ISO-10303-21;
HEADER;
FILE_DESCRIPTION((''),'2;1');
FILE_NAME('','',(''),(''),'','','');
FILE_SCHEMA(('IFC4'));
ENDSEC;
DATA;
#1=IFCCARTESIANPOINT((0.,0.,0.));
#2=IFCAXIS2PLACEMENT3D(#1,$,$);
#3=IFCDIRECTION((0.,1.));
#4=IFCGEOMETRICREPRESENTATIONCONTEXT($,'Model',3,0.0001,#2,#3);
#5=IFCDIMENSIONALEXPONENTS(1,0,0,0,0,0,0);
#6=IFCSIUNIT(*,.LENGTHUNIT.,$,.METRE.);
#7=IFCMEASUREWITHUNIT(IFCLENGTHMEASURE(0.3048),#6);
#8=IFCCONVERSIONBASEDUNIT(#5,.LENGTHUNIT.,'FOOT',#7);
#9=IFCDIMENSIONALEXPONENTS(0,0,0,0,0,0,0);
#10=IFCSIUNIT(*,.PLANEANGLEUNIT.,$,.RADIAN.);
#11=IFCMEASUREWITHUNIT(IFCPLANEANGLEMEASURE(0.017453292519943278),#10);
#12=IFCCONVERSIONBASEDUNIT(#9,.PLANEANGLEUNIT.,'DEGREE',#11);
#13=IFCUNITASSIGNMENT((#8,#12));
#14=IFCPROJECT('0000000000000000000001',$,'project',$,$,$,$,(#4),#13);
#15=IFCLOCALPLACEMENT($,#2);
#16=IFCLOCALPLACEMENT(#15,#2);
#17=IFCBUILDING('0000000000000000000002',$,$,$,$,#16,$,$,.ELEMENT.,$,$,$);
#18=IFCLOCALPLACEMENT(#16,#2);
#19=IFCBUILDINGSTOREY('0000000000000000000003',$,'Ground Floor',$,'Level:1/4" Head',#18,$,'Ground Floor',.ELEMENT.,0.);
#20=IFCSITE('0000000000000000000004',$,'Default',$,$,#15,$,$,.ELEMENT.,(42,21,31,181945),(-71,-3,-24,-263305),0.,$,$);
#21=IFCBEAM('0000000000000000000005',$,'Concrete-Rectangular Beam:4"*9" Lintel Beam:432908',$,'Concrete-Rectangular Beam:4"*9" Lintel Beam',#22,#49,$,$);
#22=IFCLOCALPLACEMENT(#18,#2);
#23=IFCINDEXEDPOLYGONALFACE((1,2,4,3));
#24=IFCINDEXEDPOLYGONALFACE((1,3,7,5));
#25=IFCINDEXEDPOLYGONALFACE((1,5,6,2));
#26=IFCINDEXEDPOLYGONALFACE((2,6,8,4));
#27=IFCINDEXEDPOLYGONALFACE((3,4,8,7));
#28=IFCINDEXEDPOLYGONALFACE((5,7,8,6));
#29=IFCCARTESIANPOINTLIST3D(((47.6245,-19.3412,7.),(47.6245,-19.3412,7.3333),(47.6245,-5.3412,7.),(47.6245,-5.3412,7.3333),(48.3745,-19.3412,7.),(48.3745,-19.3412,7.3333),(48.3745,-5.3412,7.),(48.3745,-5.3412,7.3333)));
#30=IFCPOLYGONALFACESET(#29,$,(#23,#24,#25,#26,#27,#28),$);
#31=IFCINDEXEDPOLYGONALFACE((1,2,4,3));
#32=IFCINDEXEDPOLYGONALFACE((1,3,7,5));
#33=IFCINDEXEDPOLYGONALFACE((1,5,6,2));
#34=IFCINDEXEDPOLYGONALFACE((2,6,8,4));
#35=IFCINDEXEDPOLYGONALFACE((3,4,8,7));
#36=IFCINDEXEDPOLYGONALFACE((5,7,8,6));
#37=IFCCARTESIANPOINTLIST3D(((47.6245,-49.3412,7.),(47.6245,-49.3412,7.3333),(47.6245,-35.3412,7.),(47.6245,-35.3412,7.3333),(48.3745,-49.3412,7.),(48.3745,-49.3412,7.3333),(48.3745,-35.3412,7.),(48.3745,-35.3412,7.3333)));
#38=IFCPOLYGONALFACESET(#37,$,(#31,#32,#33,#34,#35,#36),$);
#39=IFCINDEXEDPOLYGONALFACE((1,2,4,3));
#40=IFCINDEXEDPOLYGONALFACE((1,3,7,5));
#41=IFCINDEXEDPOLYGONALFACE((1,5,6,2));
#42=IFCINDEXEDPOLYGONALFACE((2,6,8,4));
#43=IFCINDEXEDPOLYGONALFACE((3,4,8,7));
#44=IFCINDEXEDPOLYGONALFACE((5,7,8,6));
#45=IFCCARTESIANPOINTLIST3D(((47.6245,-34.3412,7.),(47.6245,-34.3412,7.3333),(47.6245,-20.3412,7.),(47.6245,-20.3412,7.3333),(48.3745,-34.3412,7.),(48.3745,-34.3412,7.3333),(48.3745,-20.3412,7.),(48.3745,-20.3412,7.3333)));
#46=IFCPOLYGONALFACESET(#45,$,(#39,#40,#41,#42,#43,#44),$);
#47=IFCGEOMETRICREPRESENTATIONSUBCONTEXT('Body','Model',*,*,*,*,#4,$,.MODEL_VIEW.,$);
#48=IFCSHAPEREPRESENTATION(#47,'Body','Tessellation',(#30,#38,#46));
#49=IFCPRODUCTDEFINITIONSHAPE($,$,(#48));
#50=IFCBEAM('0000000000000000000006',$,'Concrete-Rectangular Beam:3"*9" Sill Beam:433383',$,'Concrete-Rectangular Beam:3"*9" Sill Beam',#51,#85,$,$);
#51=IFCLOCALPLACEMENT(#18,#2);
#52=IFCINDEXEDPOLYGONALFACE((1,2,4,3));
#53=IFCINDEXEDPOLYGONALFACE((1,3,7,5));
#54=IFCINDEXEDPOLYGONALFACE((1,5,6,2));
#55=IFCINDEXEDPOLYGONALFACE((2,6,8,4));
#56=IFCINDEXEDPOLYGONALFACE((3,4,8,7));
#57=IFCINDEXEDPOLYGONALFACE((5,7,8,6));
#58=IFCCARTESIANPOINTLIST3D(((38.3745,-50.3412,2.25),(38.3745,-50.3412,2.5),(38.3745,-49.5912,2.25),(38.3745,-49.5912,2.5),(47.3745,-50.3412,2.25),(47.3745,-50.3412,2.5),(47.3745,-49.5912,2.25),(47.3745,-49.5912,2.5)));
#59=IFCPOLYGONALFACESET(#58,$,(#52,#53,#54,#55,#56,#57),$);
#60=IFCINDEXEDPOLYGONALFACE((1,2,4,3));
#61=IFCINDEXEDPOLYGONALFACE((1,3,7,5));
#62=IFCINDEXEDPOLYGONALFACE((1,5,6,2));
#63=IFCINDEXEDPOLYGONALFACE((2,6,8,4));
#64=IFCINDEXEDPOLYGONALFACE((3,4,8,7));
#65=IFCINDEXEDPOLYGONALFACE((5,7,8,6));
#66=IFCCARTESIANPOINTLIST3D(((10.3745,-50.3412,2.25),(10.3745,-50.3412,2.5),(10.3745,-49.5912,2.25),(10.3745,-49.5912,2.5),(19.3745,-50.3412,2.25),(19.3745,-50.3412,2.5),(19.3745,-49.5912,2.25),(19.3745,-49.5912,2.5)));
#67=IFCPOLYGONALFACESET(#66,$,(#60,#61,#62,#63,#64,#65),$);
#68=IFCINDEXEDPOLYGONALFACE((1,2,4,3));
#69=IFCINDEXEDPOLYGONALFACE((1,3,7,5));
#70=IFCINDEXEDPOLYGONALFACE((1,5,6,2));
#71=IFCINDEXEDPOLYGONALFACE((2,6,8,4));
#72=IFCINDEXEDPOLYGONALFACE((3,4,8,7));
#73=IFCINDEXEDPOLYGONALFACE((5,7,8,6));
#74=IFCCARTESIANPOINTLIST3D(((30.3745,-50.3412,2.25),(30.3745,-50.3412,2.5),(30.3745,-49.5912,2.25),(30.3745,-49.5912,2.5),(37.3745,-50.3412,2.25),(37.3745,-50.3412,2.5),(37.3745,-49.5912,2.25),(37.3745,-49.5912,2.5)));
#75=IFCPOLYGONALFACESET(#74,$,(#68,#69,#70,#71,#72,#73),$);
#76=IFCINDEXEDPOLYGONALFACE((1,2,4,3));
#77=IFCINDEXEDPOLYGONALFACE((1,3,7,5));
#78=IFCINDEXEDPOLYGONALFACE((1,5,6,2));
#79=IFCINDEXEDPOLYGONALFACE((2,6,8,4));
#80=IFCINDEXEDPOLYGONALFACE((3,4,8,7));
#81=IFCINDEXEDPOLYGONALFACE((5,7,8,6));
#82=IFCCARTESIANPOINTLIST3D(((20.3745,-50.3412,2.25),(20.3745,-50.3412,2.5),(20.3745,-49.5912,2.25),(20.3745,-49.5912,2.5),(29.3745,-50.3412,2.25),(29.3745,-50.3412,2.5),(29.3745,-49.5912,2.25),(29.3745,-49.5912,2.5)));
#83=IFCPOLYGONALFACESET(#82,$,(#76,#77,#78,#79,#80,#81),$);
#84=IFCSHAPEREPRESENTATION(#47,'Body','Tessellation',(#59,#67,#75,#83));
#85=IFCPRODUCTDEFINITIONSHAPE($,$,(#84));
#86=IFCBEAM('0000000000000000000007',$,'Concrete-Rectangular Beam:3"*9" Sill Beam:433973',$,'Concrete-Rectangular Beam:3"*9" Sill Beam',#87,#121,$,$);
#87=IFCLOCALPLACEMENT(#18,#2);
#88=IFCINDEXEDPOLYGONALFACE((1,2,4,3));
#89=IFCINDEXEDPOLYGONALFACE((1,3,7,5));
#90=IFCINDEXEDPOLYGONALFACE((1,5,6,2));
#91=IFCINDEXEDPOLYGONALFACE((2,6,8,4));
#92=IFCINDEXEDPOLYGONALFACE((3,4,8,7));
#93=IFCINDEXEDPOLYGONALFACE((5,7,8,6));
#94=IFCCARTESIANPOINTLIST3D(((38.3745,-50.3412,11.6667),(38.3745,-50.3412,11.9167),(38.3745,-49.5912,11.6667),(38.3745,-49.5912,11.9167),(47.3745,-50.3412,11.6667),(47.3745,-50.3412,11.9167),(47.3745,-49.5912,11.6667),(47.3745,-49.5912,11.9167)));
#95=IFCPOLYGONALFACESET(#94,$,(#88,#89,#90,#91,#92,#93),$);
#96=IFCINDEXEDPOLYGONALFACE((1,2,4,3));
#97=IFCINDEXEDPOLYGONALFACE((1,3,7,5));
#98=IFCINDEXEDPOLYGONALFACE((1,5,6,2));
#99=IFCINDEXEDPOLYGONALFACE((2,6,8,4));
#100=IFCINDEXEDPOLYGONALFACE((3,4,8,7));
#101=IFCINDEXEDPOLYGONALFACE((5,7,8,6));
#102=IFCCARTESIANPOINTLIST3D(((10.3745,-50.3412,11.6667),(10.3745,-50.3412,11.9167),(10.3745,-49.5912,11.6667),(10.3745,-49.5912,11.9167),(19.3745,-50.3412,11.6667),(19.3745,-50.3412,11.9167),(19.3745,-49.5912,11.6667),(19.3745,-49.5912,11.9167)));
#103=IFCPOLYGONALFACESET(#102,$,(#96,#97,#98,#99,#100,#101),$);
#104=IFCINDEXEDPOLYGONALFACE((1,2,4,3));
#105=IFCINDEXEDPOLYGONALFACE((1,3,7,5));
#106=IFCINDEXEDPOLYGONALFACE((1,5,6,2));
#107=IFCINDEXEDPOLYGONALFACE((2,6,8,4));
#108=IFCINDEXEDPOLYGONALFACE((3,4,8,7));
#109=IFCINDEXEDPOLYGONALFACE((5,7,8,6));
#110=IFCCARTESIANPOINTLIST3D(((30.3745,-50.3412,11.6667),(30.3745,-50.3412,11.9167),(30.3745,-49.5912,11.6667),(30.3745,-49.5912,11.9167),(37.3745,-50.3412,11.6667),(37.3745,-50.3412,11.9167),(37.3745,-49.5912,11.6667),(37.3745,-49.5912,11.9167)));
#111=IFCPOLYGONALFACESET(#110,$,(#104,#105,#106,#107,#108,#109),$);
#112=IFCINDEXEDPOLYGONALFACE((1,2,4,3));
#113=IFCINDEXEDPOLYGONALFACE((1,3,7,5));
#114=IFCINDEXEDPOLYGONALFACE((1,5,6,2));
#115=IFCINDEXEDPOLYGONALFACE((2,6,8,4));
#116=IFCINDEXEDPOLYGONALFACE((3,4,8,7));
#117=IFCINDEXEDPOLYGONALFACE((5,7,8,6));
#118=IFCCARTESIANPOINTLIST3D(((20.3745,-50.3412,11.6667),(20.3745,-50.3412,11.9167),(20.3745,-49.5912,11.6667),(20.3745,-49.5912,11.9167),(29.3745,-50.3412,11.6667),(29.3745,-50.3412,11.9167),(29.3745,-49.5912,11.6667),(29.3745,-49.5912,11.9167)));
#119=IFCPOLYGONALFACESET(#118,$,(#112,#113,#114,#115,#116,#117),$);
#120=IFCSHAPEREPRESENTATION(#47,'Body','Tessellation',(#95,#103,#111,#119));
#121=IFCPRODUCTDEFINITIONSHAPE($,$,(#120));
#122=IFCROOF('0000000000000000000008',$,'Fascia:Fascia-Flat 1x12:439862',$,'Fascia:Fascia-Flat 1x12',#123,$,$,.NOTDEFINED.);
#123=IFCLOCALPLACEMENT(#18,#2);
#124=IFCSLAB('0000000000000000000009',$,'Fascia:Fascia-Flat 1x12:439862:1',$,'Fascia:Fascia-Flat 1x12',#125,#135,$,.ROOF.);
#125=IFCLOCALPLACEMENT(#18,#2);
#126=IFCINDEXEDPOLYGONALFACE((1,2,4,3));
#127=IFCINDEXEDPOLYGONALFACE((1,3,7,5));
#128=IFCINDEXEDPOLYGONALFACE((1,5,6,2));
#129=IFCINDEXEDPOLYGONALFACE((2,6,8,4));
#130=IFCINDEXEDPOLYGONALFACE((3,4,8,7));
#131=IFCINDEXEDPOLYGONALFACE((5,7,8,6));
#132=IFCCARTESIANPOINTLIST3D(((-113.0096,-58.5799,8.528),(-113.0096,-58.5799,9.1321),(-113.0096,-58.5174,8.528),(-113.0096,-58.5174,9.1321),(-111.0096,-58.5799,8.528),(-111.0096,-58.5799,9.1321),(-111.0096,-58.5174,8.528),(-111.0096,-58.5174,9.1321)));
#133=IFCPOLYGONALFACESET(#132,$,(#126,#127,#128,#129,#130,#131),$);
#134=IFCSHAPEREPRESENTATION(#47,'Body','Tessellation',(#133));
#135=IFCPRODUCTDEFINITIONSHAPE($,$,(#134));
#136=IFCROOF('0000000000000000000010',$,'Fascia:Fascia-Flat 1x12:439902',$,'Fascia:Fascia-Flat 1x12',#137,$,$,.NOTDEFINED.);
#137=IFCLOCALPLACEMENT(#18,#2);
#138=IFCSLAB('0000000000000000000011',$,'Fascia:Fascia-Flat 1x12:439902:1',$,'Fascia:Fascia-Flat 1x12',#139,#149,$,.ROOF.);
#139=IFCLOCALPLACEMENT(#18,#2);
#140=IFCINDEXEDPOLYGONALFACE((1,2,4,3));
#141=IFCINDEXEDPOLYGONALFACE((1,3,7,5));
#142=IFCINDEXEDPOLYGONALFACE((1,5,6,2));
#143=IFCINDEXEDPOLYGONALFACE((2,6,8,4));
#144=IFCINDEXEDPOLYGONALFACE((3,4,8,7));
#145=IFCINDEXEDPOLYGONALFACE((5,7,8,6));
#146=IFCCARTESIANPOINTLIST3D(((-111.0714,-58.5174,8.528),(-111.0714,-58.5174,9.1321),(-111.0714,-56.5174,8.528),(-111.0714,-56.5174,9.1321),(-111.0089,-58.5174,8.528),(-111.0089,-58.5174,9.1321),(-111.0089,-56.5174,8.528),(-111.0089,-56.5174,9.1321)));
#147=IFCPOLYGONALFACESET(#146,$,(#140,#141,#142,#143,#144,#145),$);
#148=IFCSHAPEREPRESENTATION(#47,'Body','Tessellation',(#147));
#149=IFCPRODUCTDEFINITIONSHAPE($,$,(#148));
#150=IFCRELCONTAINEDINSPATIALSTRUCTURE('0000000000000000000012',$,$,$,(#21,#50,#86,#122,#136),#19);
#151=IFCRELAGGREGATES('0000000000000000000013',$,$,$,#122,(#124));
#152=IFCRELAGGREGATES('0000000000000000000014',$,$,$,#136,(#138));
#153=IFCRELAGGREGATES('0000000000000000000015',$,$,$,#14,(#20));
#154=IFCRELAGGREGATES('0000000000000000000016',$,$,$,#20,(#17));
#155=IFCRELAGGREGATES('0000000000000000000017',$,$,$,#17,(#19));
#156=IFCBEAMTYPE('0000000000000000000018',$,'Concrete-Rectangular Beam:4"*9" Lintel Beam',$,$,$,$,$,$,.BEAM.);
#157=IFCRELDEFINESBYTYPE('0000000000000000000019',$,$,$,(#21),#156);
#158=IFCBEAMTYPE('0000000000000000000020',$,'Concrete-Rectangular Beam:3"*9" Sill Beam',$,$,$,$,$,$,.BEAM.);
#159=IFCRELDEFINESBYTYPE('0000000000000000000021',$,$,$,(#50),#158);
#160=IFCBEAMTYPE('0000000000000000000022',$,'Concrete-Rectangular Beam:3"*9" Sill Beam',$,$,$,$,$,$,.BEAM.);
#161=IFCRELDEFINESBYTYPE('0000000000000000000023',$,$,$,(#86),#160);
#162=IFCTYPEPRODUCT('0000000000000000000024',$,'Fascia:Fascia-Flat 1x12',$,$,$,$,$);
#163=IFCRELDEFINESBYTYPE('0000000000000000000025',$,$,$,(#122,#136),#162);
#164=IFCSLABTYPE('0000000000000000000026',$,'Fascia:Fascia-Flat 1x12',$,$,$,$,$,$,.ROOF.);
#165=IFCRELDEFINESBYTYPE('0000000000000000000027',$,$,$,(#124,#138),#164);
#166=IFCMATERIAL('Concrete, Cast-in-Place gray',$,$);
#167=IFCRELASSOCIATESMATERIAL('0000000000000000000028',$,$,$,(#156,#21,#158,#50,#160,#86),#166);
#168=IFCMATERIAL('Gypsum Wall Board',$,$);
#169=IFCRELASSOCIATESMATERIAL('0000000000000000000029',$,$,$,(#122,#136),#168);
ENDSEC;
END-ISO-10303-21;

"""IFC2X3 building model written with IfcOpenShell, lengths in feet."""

from ifc_helpers import new_model, entity, si_unit, converted_unit, direction, frame, frame_2d, origin, origin_2d_with_axis, place, context, subcontext, project, spatial, rectangle, extrude, source, transform, mapped, material, type_object, type_shapes, element, aggregate, save


model = new_model("IFC2X3")

# Units and contexts
model_context = context("Model", 3, precision=0.0001, world=origin(), true_north=direction((0.0, 1.0)))
body_context = subcontext(model_context, "Body", "Model", "MODEL_VIEW")
ifc_project = project(units=[converted_unit("LENGTHUNIT", "FOOT", entity("IfcLengthMeasure", 0.3048), si_unit("LENGTHUNIT", "METRE"), dimensions=[1, 0, 0, 0, 0, 0, 0]), converted_unit("PLANEANGLEUNIT", "DEGREE", entity("IfcPlaneAngleMeasure", 0.017453292519943278), si_unit("PLANEANGLEUNIT", "RADIAN"), dimensions=[0, 0, 0, 0, 0, 0, 0])], contexts=[model_context])

# Site, building, storey
site_placement = place(None, origin())
site = spatial("IfcSite", under=ifc_project, at=site_placement, Name="Default", CompositionType="ELEMENT", RefLatitude=(42, 21, 31, 181945), RefLongitude=(-71, -3, -24, -263305), RefElevation=0.0)
building_placement = place(site_placement, origin())
building = spatial("IfcBuilding", under=site, at=building_placement, CompositionType="ELEMENT")
storey_placement = place(building_placement, origin())
storey = spatial("IfcBuildingStorey", under=building, at=storey_placement, Name="Ground Floor", ObjectType="Level:1/4\" Head", LongName="Ground Floor", CompositionType="ELEMENT", Elevation=0.0)

# Shared definitions
ifc_material_1 = material(Name="Concrete, Cast-in-Place gray")

# Beams
beam_type_1 = type_object("IfcBeamType", Name="Concrete-Rectangular Beam:4\"*9\" Lintel Beam", PredefinedType="BEAM", material=ifc_material_1)
shared_shape_1 = source(origin(), body_context, "Body", "SweptSolid", [
    extrude(rectangle(XDim=0.3333, YDim=0.75, at=frame_2d((0.0, 0.0), x_axis=(0.0, 1.0))), frame((47.9995, -19.3412, 7.1667), z_axis=(0.0, 1.0, 0.0), x_axis=(-1.0, 0.0, 0.0)), (0.0, 0.0, 1.0), 14.0),
    extrude(rectangle(XDim=0.3333, YDim=0.75, at=frame_2d((0.0, 0.0), x_axis=(0.0, 1.0))), frame((47.9995, -49.3412, 7.1667), z_axis=(0.0, 1.0, 0.0), x_axis=(-1.0, 0.0, 0.0)), (0.0, 0.0, 1.0), 14.0),
    extrude(rectangle(XDim=0.3333, YDim=0.75, at=frame_2d((0.0, 0.0), x_axis=(0.0, 1.0))), frame((47.9995, -34.3412, 7.1667), z_axis=(0.0, 1.0, 0.0), x_axis=(-1.0, 0.0, 0.0)), (0.0, 0.0, 1.0), 14.0),
])
type_shapes(beam_type_1, [shared_shape_1])
beam_1_placement = place(storey_placement, origin())
element("IfcBeam", 1, at=beam_1_placement, inside=storey, type_object=beam_type_1, material=ifc_material_1, Name="Concrete-Rectangular Beam:4\"*9\" Lintel Beam:432908", ObjectType="Concrete-Rectangular Beam:4\"*9\" Lintel Beam", context=body_context, shape_type="MappedRepresentation", body=[
    mapped(shared_shape_1, transform((0.0, 0.0, 0.0), scale=1.0)),
])
beam_type_2 = type_object("IfcBeamType", Name="Concrete-Rectangular Beam:3\"*9\" Sill Beam", PredefinedType="BEAM", material=ifc_material_1)
shared_shape_2 = source(origin(), body_context, "Body", "SweptSolid", [
    extrude(rectangle(XDim=0.25, YDim=0.75, at=frame_2d((0.0, 0.0), x_axis=(1.0, 0.0))), frame((38.3745, -49.9662, 2.375), z_axis=(1.0, 0.0, 0.0), x_axis=(0.0, 0.0, -1.0)), (0.0, 0.0, 1.0), 9.0),
    extrude(rectangle(XDim=0.25, YDim=0.75, at=frame_2d((0.0, 0.0), x_axis=(1.0, 0.0))), frame((10.3745, -49.9662, 2.375), z_axis=(1.0, 0.0, 0.0), x_axis=(0.0, 0.0, -1.0)), (0.0, 0.0, 1.0), 9.0),
    extrude(rectangle(XDim=0.25, YDim=0.75, at=frame_2d((0.0, 0.0), x_axis=(1.0, 0.0))), frame((30.3745, -49.9662, 2.375), z_axis=(1.0, 0.0, 0.0), x_axis=(0.0, 0.0, -1.0)), (0.0, 0.0, 1.0), 7.0),
    extrude(rectangle(XDim=0.25, YDim=0.75, at=frame_2d((0.0, 0.0), x_axis=(1.0, 0.0))), frame((20.3745, -49.9662, 2.375), z_axis=(1.0, 0.0, 0.0), x_axis=(0.0, 0.0, -1.0)), (0.0, 0.0, 1.0), 9.0),
])
type_shapes(beam_type_2, [shared_shape_2])
beam_2_placement = place(storey_placement, origin())
element("IfcBeam", 2, at=beam_2_placement, inside=storey, type_object=beam_type_2, material=ifc_material_1, Name="Concrete-Rectangular Beam:3\"*9\" Sill Beam:433383", ObjectType="Concrete-Rectangular Beam:3\"*9\" Sill Beam", context=body_context, shape_type="MappedRepresentation", body=[
    mapped(shared_shape_2, transform((0.0, 0.0, 0.0), scale=1.0)),
])
beam_type_3 = type_object("IfcBeamType", Name="Concrete-Rectangular Beam:3\"*9\" Sill Beam", PredefinedType="BEAM", material=ifc_material_1)
shared_shape_3 = source(origin(), body_context, "Body", "SweptSolid", [
    extrude(rectangle(XDim=0.25, YDim=0.75, at=frame_2d((0.0, 0.0), x_axis=(1.0, 0.0))), frame((38.3745, -49.9662, 11.7917), z_axis=(1.0, 0.0, 0.0), x_axis=(0.0, 0.0, -1.0)), (0.0, 0.0, 1.0), 9.0),
    extrude(rectangle(XDim=0.25, YDim=0.75, at=frame_2d((0.0, 0.0), x_axis=(1.0, 0.0))), frame((10.3745, -49.9662, 11.7917), z_axis=(1.0, 0.0, 0.0), x_axis=(0.0, 0.0, -1.0)), (0.0, 0.0, 1.0), 9.0),
    extrude(rectangle(XDim=0.25, YDim=0.75, at=origin_2d_with_axis()), frame((30.3745, -49.9662, 11.7917), z_axis=(1.0, 0.0, 0.0), x_axis=(0.0, 0.0, -1.0)), (0.0, 0.0, 1.0), 7.0),
    extrude(rectangle(XDim=0.25, YDim=0.75, at=origin_2d_with_axis()), frame((20.3745, -49.9662, 11.7917), z_axis=(1.0, 0.0, 0.0), x_axis=(0.0, 0.0, -1.0)), (0.0, 0.0, 1.0), 9.0),
])
type_shapes(beam_type_3, [shared_shape_3])
beam_3_placement = place(storey_placement, origin())
element("IfcBeam", 3, at=beam_3_placement, inside=storey, type_object=beam_type_3, material=ifc_material_1, Name="Concrete-Rectangular Beam:3\"*9\" Sill Beam:433973", ObjectType="Concrete-Rectangular Beam:3\"*9\" Sill Beam", context=body_context, shape_type="MappedRepresentation", body=[
    mapped(shared_shape_3, transform((0.0, 0.0, 0.0), scale=1.0)),
])

# Roofs, slabs
ifc_material_2 = material(Name="Gypsum Wall Board")
type_product_1 = type_object("IfcTypeProduct", Name="Fascia:Fascia-Flat 1x12")
roof_1_placement = place(storey_placement, origin())
roof_1 = element("IfcRoof", 4, at=roof_1_placement, inside=storey, type_object=type_product_1, material=ifc_material_2, Name="Fascia:Fascia-Flat 1x12:439862", ObjectType="Fascia:Fascia-Flat 1x12", ShapeType="NOTDEFINED")
slab_type_1 = type_object("IfcSlabType", Name="Fascia:Fascia-Flat 1x12", PredefinedType="ROOF")
slab_1_placement = place(storey_placement, origin())
slab_1 = element("IfcSlab", 5, at=slab_1_placement, type_object=slab_type_1, Name="Fascia:Fascia-Flat 1x12:439862:1", ObjectType="Fascia:Fascia-Flat 1x12", PredefinedType="ROOF", context=body_context, shape_type="SweptSolid", body=[
    extrude(rectangle(XDim=2.0, YDim=0.0625, at=frame_2d((0.0, 0.0), x_axis=(1.0, 0.0))), frame((-112.0096, -58.5487, 8.528)), (0.0, 0.0, 1.0), 0.6042),
])
aggregate(roof_1, [slab_1])
roof_2_placement = place(storey_placement, origin())
roof_2 = element("IfcRoof", 6, at=roof_2_placement, inside=storey, type_object=type_product_1, material=ifc_material_2, Name="Fascia:Fascia-Flat 1x12:439902", ObjectType="Fascia:Fascia-Flat 1x12", ShapeType="NOTDEFINED")
slab_2_placement = place(storey_placement, origin())
slab_2 = element("IfcSlab", 7, at=slab_2_placement, type_object=slab_type_1, Name="Fascia:Fascia-Flat 1x12:439902:1", ObjectType="Fascia:Fascia-Flat 1x12", PredefinedType="ROOF", context=body_context, shape_type="SweptSolid", body=[
    extrude(rectangle(XDim=2.0, YDim=0.0625, at=origin_2d_with_axis()), frame((-111.0402, -57.5174, 8.528), z_axis=(0.0, 0.0, 1.0), x_axis=(0.0, 1.0, 0.0)), (0.0, 0.0, 1.0), 0.6042),
])
aggregate(roof_2, [slab_2])

save(model, "model.ifc")
